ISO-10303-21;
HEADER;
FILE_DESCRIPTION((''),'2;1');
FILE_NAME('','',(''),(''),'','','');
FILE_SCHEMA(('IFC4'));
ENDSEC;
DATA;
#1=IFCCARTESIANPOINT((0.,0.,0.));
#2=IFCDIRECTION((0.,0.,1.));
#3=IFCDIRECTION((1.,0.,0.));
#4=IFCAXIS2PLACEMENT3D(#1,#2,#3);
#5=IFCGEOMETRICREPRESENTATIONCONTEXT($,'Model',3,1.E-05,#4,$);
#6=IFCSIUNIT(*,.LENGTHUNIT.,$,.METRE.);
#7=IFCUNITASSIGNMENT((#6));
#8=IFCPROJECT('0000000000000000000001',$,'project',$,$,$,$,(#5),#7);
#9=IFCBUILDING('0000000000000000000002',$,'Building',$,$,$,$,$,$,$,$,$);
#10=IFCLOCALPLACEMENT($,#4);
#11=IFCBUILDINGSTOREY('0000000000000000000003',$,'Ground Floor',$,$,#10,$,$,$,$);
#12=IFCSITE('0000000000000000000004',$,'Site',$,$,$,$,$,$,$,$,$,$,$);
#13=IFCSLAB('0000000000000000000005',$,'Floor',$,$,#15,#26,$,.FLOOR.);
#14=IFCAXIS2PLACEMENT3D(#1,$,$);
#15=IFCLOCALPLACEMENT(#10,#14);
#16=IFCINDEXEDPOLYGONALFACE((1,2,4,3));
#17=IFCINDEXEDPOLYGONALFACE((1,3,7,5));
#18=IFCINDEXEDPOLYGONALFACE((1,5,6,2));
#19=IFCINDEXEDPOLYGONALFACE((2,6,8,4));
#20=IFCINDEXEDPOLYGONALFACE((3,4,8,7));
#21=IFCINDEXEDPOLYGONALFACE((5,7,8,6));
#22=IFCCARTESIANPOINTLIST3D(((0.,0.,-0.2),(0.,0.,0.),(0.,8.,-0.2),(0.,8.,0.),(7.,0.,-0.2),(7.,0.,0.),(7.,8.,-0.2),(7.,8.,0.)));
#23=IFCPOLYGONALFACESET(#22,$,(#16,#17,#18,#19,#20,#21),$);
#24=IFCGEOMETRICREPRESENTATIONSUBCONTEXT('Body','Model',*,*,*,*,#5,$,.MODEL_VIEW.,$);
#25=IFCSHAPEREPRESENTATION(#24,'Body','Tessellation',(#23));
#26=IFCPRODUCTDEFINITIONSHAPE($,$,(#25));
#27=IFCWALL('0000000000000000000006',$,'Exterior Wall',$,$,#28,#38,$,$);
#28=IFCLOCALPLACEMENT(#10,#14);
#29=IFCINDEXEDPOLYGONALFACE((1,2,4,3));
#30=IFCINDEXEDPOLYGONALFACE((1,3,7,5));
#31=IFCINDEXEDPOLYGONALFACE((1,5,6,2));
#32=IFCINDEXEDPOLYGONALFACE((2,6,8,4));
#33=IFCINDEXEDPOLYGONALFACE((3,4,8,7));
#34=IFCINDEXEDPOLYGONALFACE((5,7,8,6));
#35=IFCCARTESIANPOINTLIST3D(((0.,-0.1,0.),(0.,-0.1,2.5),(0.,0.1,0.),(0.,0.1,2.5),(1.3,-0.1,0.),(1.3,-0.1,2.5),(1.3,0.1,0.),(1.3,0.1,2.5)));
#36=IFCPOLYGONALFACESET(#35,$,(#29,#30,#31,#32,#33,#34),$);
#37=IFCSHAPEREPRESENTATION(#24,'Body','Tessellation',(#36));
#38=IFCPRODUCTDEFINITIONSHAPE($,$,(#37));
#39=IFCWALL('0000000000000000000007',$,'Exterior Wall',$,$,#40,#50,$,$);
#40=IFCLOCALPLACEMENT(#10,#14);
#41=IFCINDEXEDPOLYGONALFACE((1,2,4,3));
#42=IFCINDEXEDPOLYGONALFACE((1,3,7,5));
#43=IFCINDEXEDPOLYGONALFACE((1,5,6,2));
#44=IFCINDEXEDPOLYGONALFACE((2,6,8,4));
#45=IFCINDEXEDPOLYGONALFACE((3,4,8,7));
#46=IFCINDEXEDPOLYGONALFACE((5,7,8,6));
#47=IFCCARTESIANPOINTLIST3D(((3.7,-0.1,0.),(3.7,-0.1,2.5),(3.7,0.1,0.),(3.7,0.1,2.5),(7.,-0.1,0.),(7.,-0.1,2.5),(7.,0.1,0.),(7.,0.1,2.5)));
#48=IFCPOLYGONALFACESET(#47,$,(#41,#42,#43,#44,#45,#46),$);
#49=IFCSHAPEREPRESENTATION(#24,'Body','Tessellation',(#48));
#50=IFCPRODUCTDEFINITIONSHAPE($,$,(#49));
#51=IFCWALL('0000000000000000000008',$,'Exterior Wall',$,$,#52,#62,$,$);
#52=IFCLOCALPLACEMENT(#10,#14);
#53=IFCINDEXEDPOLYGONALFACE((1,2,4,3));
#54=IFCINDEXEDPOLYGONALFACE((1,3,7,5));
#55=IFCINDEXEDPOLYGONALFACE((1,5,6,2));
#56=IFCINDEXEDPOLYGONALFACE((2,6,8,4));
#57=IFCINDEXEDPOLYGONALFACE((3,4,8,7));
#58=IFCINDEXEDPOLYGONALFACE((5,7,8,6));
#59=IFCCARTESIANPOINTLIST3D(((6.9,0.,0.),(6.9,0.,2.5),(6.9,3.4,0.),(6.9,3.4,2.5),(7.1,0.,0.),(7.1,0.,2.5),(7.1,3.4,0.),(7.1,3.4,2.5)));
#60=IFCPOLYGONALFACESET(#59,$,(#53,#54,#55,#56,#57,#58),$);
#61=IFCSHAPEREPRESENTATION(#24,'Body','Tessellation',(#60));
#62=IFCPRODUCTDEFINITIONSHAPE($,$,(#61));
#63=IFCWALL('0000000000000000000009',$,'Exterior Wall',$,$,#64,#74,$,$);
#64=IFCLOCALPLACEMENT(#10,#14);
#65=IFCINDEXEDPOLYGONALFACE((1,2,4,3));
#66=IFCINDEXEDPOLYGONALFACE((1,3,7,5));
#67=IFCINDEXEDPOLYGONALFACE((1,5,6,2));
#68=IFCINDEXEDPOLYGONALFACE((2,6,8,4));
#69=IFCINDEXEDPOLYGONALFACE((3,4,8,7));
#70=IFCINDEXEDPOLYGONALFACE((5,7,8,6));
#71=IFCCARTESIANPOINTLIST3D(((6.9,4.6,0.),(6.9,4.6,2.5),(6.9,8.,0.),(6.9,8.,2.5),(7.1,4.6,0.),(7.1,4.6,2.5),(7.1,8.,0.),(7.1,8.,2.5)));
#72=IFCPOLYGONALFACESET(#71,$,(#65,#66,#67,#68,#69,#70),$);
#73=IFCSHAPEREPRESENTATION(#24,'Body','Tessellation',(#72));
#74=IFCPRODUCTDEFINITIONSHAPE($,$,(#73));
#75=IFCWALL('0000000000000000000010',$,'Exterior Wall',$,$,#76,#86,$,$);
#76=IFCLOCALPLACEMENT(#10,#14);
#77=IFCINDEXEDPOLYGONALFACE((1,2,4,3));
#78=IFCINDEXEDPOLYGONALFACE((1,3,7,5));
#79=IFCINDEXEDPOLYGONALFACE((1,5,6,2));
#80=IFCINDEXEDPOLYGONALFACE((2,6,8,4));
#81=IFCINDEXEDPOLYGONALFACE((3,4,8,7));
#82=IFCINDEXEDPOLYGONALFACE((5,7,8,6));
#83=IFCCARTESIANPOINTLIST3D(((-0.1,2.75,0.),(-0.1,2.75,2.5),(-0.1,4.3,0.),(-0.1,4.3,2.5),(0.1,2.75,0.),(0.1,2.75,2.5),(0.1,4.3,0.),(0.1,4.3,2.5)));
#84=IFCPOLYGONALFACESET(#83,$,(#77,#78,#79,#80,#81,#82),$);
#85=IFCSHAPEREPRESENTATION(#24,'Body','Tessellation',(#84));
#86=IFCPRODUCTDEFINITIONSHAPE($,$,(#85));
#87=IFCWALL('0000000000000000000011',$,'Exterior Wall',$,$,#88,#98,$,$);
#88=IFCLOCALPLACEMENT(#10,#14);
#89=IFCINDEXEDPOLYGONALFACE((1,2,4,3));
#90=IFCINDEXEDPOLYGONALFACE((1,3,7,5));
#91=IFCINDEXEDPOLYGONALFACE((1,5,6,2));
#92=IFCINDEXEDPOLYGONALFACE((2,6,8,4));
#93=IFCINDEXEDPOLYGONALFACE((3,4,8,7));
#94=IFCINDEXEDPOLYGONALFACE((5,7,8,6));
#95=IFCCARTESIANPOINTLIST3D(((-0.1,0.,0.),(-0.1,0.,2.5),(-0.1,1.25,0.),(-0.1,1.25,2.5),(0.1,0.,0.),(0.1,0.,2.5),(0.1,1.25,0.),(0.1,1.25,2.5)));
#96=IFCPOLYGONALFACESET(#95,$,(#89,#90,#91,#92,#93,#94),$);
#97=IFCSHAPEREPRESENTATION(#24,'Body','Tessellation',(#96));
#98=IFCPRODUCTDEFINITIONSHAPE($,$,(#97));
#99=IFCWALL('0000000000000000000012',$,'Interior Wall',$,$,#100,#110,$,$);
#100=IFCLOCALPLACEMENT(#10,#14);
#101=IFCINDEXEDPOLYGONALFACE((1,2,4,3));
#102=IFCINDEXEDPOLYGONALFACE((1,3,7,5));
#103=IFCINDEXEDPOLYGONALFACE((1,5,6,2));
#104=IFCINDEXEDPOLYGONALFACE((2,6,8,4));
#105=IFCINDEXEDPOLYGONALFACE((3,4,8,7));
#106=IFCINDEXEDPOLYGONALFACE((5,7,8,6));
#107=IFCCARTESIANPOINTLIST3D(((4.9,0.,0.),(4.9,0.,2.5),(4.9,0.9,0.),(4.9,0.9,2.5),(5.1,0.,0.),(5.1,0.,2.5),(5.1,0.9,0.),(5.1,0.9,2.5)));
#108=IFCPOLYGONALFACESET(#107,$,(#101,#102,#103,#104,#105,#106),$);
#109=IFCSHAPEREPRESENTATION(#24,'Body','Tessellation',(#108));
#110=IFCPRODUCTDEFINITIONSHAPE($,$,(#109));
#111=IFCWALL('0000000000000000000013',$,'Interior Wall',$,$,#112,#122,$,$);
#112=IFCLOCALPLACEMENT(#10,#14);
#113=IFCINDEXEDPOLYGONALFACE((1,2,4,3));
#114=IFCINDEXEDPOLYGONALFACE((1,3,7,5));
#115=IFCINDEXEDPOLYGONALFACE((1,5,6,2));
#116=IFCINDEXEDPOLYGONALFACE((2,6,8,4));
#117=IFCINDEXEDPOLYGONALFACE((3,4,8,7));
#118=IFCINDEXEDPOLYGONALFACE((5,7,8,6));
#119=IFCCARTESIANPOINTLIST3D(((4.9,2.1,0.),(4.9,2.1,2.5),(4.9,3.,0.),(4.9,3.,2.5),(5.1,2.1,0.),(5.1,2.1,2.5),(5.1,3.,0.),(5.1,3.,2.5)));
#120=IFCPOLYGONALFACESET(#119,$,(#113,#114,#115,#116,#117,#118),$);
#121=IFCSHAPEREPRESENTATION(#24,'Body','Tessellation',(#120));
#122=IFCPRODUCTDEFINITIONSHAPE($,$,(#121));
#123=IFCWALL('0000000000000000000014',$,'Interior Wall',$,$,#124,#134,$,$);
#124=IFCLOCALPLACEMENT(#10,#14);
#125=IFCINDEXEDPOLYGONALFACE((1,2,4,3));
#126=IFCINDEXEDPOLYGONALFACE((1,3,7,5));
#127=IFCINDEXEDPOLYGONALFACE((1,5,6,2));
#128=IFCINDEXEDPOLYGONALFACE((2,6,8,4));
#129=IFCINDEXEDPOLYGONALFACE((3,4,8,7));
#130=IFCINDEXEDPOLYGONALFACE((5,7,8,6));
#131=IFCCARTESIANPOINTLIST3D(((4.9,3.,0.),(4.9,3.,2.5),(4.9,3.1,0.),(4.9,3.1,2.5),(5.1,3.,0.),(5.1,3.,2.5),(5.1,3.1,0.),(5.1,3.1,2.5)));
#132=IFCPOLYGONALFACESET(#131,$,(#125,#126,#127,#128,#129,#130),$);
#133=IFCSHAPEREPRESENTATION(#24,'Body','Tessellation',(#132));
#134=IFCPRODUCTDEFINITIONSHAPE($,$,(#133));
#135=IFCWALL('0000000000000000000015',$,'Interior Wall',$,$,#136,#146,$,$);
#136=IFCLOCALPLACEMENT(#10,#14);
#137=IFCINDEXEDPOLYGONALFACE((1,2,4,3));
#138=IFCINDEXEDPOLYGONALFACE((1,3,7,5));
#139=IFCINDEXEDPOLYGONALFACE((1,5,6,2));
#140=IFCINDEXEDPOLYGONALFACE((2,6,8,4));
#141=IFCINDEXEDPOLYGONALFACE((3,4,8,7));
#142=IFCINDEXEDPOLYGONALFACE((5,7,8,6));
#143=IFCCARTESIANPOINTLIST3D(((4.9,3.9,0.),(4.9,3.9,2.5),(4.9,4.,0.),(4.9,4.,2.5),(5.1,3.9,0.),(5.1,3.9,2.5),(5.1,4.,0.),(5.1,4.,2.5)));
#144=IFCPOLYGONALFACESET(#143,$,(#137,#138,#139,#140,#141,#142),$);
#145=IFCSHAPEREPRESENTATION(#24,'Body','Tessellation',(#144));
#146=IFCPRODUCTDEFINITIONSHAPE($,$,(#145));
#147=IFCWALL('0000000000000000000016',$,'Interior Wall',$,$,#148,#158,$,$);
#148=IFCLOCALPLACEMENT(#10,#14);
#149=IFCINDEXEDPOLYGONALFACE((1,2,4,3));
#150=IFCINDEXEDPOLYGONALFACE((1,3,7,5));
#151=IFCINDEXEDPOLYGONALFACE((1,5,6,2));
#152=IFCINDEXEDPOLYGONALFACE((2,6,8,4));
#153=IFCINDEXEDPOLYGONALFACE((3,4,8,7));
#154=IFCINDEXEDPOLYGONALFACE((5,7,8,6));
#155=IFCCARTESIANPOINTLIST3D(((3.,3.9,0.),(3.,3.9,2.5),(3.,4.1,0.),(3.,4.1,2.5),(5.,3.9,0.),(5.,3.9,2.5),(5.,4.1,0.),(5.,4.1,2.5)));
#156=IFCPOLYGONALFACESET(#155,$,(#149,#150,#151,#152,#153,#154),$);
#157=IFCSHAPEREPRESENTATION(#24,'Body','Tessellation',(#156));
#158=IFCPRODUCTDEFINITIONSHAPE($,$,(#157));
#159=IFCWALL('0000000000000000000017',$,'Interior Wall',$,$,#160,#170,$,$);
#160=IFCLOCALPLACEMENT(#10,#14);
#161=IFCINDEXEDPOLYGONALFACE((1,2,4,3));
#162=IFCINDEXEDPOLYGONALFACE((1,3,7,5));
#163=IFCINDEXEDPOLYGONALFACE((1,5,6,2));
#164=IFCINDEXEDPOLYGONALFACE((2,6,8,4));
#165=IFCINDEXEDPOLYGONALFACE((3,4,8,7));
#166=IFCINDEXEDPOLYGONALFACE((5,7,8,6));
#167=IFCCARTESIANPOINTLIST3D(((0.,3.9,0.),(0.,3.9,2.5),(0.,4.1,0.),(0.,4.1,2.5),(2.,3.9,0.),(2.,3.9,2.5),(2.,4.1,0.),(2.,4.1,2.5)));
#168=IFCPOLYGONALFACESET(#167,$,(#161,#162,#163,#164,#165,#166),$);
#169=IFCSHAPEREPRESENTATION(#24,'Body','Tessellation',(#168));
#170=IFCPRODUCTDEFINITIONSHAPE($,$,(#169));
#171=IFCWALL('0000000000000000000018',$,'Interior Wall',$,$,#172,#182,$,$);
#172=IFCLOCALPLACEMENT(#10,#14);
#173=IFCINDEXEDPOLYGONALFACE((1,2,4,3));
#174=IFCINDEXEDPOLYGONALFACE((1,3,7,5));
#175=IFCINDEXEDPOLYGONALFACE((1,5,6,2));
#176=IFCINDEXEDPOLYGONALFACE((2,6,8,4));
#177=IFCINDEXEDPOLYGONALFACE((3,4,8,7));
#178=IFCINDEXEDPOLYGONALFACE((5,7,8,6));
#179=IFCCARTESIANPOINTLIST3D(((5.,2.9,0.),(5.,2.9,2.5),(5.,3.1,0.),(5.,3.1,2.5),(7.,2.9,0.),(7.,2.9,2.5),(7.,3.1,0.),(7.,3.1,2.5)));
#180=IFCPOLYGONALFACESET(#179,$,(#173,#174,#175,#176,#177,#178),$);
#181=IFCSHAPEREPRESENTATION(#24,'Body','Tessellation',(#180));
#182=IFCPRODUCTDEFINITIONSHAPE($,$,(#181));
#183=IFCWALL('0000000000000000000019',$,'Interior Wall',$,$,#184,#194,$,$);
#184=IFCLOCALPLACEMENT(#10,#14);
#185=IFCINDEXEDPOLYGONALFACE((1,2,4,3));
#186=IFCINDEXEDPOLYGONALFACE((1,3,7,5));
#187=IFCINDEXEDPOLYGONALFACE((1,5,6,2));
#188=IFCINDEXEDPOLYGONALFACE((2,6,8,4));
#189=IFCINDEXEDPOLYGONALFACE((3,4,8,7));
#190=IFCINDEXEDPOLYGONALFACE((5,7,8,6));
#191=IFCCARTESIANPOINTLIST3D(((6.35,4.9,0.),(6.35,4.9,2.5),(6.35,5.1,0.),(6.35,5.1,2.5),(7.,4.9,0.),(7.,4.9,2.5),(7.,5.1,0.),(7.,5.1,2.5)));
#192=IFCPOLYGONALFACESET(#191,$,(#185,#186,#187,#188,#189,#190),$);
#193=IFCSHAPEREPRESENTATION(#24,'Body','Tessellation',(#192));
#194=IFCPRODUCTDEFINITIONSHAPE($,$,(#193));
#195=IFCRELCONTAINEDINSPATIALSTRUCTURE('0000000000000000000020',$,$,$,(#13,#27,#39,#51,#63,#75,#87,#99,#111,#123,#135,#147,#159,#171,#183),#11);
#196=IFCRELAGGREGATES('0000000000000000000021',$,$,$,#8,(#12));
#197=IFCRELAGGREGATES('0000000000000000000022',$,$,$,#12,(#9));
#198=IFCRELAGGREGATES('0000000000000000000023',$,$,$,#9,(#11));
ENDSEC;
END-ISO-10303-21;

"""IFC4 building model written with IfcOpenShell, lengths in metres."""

from ifc_helpers import new_model, si_unit, frame, origin_with_axes, place, context, subcontext, project, spatial, indexed_curve, outline, extrude, element, save


model = new_model("IFC4")

# Units and contexts
model_context = context("Model", 3, precision=1e-05, world=origin_with_axes())
body_context = subcontext(model_context, "Body", "Model", "MODEL_VIEW")
ifc_project = project(units=[si_unit("LENGTHUNIT", "METRE")], contexts=[model_context])

# Site, building, storey
site = spatial("IfcSite", under=ifc_project, Name="Site")
building = spatial("IfcBuilding", under=site, Name="Building")
storey_placement = place(None, origin_with_axes())
storey = spatial("IfcBuildingStorey", under=building, at=storey_placement, Name="Ground Floor")

# Slab
slab_placement = place(storey_placement, frame((0.0, 0.0, -0.2), z_axis=(0.0, 0.0, 1.0), x_axis=(1.0, 0.0, 0.0)))
element("IfcSlab", 1, at=slab_placement, inside=storey, Name="Floor", PredefinedType="FLOOR", context=body_context, shape_type="SweptSolid", body=[
    extrude(outline(indexed_curve([(0.0, 0.0), (7.0, 0.0), (7.0, 8.0), (0.0, 8.0)])), None, (0.0, 0.0, 1.0), 0.2),
])

# Walls
wall_1_placement = place(storey_placement, origin_with_axes())
element("IfcWall", 2, at=wall_1_placement, inside=storey, Name="Exterior Wall", context=body_context, shape_type="SweptSolid", body=[
    extrude(outline(indexed_curve([(0.0, 0.0), (0.0, 0.2), (1.3, 0.2), (1.3, 0.0), (0.0, 0.0)], self_intersect=False)), frame((0.0, -0.1, 0.0), z_axis=(0.0, 0.0, 1.0), x_axis=(1.0, 0.0, 0.0)), (0.0, 0.0, 1.0), 2.5),
])
wall_2_placement = place(storey_placement, frame((3.7, 0.0, 0.0), z_axis=(0.0, 0.0, 1.0), x_axis=(1.0, 0.0, 0.0)))
element("IfcWall", 3, at=wall_2_placement, inside=storey, Name="Exterior Wall", context=body_context, shape_type="SweptSolid", body=[
    extrude(outline(indexed_curve([(0.0, 0.0), (0.0, 0.2), (3.3, 0.2), (3.3, 0.0), (0.0, 0.0)], self_intersect=False)), frame((0.0, -0.1, 0.0), z_axis=(0.0, 0.0, 1.0), x_axis=(1.0, 0.0, 0.0)), (0.0, 0.0, 1.0), 2.5),
])
wall_3_placement = place(storey_placement, frame((7.0, 0.0, 0.0), z_axis=(0.0, 0.0, 1.0), x_axis=(0.0, 1.0, 0.0)))
element("IfcWall", 4, at=wall_3_placement, inside=storey, Name="Exterior Wall", context=body_context, shape_type="SweptSolid", body=[
    extrude(outline(indexed_curve([(0.0, 0.0), (0.0, 0.2), (3.4, 0.2), (3.4, 0.0), (0.0, 0.0)], self_intersect=False)), frame((0.0, -0.1, 0.0), z_axis=(0.0, 0.0, 1.0), x_axis=(1.0, 0.0, 0.0)), (0.0, 0.0, 1.0), 2.5),
])
wall_4_placement = place(storey_placement, frame((7.0, 4.6, 0.0), z_axis=(0.0, 0.0, 1.0), x_axis=(0.0, 1.0, 0.0)))
element("IfcWall", 5, at=wall_4_placement, inside=storey, Name="Exterior Wall", context=body_context, shape_type="SweptSolid", body=[
    extrude(outline(indexed_curve([(0.0, 0.0), (0.0, 0.2), (3.4, 0.2), (3.4, 0.0), (0.0, 0.0)], self_intersect=False)), frame((0.0, -0.1, 0.0), z_axis=(0.0, 0.0, 1.0), x_axis=(1.0, 0.0, 0.0)), (0.0, 0.0, 1.0), 2.5),
])
wall_5_placement = place(storey_placement, frame((0.0, 4.3, 0.0), z_axis=(0.0, 0.0, 1.0), x_axis=(0.0, -1.0, 0.0)))
element("IfcWall", 6, at=wall_5_placement, inside=storey, Name="Exterior Wall", context=body_context, shape_type="SweptSolid", body=[
    extrude(outline(indexed_curve([(0.0, 0.0), (0.0, 0.2), (1.55, 0.2), (1.55, 0.0), (0.0, 0.0)], self_intersect=False)), frame((0.0, -0.1, 0.0), z_axis=(0.0, 0.0, 1.0), x_axis=(1.0, 0.0, 0.0)), (0.0, 0.0, 1.0), 2.5),
])
wall_6_placement = place(storey_placement, frame((0.0, 1.25, 0.0), z_axis=(0.0, 0.0, 1.0), x_axis=(0.0, -1.0, 0.0)))
element("IfcWall", 7, at=wall_6_placement, inside=storey, Name="Exterior Wall", context=body_context, shape_type="SweptSolid", body=[
    extrude(outline(indexed_curve([(0.0, 0.0), (0.0, 0.2), (1.25, 0.2), (1.25, 0.0), (0.0, 0.0)], self_intersect=False)), frame((0.0, -0.1, 0.0), z_axis=(0.0, 0.0, 1.0), x_axis=(1.0, 0.0, 0.0)), (0.0, 0.0, 1.0), 2.5),
])
wall_7_placement = place(storey_placement, frame((5.0, 0.0, 0.0), z_axis=(0.0, 0.0, 1.0), x_axis=(0.0, 1.0, 0.0)))
element("IfcWall", 8, at=wall_7_placement, inside=storey, Name="Interior Wall", context=body_context, shape_type="SweptSolid", body=[
    extrude(outline(indexed_curve([(0.0, 0.0), (0.0, 0.2), (0.9, 0.2), (0.9, 0.0), (0.0, 0.0)], self_intersect=False)), frame((0.0, -0.1, 0.0), z_axis=(0.0, 0.0, 1.0), x_axis=(1.0, 0.0, 0.0)), (0.0, 0.0, 1.0), 2.5),
])
wall_8_placement = place(storey_placement, frame((5.0, 2.1, 0.0), z_axis=(0.0, 0.0, 1.0), x_axis=(0.0, 1.0, 0.0)))
element("IfcWall", 9, at=wall_8_placement, inside=storey, Name="Interior Wall", context=body_context, shape_type="SweptSolid", body=[
    extrude(outline(indexed_curve([(0.0, 0.0), (0.0, 0.2), (0.9, 0.2), (0.9, 0.0), (0.0, 0.0)], self_intersect=False)), frame((0.0, -0.1, 0.0), z_axis=(0.0, 0.0, 1.0), x_axis=(1.0, 0.0, 0.0)), (0.0, 0.0, 1.0), 2.5),
])
for number, where, z_axis, x_axis, name in (
    (10, (5.0, 3.0, 0.0), (0.0, 0.0, 1.0), (0.0, 1.0, 0.0), "Interior Wall"),
    (11, (5.0, 3.9, 0.0), (0.0, 0.0, 1.0), (0.0, 1.0, 0.0), "Interior Wall"),
):
    element("IfcWall", number, at=place(storey_placement, frame(where, z_axis=z_axis, x_axis=x_axis)), inside=storey, Name=name, context=body_context, shape_type="SweptSolid", body=[
        extrude(outline(indexed_curve([(0.0, 0.0), (0.0, 0.2), (0.1, 0.2), (0.1, 0.0), (0.0, 0.0)], self_intersect=False)), frame((0.0, -0.1, 0.0), z_axis=(0.0, 0.0, 1.0), x_axis=(1.0, 0.0, 0.0)), (0.0, 0.0, 1.0), 2.5),
    ])
for number, where, z_axis, x_axis, name in (
    (12, (5.0, 4.0, 0.0), (0.0, 0.0, 1.0), (-1.0, 0.0, 0.0), "Interior Wall"),
    (13, (2.0, 4.0, 0.0), (0.0, 0.0, 1.0), (-1.0, 0.0, 0.0), "Interior Wall"),
    (14, (7.0, 3.0, 0.0), (0.0, 0.0, 1.0), (-1.0, 0.0, 0.0), "Interior Wall"),
):
    element("IfcWall", number, at=place(storey_placement, frame(where, z_axis=z_axis, x_axis=x_axis)), inside=storey, Name=name, context=body_context, shape_type="SweptSolid", body=[
        extrude(outline(indexed_curve([(0.0, 0.0), (0.0, 0.2), (2.0, 0.2), (2.0, 0.0), (0.0, 0.0)], self_intersect=False)), frame((0.0, -0.1, 0.0), z_axis=(0.0, 0.0, 1.0), x_axis=(1.0, 0.0, 0.0)), (0.0, 0.0, 1.0), 2.5),
    ])
wall_9_placement = place(storey_placement, frame((7.0, 5.0, 0.0), z_axis=(0.0, 0.0, 1.0), x_axis=(-1.0, 0.0, 0.0)))
element("IfcWall", 15, at=wall_9_placement, inside=storey, Name="Interior Wall", context=body_context, shape_type="SweptSolid", body=[
    extrude(outline(indexed_curve([(0.0, 0.0), (0.0, 0.2), (0.65, 0.2), (0.65, 0.0), (0.0, 0.0)], self_intersect=False)), frame((0.0, -0.1, 0.0), z_axis=(0.0, 0.0, 1.0), x_axis=(1.0, 0.0, 0.0)), (0.0, 0.0, 1.0), 2.5),
])

save(model, "model.ifc")
